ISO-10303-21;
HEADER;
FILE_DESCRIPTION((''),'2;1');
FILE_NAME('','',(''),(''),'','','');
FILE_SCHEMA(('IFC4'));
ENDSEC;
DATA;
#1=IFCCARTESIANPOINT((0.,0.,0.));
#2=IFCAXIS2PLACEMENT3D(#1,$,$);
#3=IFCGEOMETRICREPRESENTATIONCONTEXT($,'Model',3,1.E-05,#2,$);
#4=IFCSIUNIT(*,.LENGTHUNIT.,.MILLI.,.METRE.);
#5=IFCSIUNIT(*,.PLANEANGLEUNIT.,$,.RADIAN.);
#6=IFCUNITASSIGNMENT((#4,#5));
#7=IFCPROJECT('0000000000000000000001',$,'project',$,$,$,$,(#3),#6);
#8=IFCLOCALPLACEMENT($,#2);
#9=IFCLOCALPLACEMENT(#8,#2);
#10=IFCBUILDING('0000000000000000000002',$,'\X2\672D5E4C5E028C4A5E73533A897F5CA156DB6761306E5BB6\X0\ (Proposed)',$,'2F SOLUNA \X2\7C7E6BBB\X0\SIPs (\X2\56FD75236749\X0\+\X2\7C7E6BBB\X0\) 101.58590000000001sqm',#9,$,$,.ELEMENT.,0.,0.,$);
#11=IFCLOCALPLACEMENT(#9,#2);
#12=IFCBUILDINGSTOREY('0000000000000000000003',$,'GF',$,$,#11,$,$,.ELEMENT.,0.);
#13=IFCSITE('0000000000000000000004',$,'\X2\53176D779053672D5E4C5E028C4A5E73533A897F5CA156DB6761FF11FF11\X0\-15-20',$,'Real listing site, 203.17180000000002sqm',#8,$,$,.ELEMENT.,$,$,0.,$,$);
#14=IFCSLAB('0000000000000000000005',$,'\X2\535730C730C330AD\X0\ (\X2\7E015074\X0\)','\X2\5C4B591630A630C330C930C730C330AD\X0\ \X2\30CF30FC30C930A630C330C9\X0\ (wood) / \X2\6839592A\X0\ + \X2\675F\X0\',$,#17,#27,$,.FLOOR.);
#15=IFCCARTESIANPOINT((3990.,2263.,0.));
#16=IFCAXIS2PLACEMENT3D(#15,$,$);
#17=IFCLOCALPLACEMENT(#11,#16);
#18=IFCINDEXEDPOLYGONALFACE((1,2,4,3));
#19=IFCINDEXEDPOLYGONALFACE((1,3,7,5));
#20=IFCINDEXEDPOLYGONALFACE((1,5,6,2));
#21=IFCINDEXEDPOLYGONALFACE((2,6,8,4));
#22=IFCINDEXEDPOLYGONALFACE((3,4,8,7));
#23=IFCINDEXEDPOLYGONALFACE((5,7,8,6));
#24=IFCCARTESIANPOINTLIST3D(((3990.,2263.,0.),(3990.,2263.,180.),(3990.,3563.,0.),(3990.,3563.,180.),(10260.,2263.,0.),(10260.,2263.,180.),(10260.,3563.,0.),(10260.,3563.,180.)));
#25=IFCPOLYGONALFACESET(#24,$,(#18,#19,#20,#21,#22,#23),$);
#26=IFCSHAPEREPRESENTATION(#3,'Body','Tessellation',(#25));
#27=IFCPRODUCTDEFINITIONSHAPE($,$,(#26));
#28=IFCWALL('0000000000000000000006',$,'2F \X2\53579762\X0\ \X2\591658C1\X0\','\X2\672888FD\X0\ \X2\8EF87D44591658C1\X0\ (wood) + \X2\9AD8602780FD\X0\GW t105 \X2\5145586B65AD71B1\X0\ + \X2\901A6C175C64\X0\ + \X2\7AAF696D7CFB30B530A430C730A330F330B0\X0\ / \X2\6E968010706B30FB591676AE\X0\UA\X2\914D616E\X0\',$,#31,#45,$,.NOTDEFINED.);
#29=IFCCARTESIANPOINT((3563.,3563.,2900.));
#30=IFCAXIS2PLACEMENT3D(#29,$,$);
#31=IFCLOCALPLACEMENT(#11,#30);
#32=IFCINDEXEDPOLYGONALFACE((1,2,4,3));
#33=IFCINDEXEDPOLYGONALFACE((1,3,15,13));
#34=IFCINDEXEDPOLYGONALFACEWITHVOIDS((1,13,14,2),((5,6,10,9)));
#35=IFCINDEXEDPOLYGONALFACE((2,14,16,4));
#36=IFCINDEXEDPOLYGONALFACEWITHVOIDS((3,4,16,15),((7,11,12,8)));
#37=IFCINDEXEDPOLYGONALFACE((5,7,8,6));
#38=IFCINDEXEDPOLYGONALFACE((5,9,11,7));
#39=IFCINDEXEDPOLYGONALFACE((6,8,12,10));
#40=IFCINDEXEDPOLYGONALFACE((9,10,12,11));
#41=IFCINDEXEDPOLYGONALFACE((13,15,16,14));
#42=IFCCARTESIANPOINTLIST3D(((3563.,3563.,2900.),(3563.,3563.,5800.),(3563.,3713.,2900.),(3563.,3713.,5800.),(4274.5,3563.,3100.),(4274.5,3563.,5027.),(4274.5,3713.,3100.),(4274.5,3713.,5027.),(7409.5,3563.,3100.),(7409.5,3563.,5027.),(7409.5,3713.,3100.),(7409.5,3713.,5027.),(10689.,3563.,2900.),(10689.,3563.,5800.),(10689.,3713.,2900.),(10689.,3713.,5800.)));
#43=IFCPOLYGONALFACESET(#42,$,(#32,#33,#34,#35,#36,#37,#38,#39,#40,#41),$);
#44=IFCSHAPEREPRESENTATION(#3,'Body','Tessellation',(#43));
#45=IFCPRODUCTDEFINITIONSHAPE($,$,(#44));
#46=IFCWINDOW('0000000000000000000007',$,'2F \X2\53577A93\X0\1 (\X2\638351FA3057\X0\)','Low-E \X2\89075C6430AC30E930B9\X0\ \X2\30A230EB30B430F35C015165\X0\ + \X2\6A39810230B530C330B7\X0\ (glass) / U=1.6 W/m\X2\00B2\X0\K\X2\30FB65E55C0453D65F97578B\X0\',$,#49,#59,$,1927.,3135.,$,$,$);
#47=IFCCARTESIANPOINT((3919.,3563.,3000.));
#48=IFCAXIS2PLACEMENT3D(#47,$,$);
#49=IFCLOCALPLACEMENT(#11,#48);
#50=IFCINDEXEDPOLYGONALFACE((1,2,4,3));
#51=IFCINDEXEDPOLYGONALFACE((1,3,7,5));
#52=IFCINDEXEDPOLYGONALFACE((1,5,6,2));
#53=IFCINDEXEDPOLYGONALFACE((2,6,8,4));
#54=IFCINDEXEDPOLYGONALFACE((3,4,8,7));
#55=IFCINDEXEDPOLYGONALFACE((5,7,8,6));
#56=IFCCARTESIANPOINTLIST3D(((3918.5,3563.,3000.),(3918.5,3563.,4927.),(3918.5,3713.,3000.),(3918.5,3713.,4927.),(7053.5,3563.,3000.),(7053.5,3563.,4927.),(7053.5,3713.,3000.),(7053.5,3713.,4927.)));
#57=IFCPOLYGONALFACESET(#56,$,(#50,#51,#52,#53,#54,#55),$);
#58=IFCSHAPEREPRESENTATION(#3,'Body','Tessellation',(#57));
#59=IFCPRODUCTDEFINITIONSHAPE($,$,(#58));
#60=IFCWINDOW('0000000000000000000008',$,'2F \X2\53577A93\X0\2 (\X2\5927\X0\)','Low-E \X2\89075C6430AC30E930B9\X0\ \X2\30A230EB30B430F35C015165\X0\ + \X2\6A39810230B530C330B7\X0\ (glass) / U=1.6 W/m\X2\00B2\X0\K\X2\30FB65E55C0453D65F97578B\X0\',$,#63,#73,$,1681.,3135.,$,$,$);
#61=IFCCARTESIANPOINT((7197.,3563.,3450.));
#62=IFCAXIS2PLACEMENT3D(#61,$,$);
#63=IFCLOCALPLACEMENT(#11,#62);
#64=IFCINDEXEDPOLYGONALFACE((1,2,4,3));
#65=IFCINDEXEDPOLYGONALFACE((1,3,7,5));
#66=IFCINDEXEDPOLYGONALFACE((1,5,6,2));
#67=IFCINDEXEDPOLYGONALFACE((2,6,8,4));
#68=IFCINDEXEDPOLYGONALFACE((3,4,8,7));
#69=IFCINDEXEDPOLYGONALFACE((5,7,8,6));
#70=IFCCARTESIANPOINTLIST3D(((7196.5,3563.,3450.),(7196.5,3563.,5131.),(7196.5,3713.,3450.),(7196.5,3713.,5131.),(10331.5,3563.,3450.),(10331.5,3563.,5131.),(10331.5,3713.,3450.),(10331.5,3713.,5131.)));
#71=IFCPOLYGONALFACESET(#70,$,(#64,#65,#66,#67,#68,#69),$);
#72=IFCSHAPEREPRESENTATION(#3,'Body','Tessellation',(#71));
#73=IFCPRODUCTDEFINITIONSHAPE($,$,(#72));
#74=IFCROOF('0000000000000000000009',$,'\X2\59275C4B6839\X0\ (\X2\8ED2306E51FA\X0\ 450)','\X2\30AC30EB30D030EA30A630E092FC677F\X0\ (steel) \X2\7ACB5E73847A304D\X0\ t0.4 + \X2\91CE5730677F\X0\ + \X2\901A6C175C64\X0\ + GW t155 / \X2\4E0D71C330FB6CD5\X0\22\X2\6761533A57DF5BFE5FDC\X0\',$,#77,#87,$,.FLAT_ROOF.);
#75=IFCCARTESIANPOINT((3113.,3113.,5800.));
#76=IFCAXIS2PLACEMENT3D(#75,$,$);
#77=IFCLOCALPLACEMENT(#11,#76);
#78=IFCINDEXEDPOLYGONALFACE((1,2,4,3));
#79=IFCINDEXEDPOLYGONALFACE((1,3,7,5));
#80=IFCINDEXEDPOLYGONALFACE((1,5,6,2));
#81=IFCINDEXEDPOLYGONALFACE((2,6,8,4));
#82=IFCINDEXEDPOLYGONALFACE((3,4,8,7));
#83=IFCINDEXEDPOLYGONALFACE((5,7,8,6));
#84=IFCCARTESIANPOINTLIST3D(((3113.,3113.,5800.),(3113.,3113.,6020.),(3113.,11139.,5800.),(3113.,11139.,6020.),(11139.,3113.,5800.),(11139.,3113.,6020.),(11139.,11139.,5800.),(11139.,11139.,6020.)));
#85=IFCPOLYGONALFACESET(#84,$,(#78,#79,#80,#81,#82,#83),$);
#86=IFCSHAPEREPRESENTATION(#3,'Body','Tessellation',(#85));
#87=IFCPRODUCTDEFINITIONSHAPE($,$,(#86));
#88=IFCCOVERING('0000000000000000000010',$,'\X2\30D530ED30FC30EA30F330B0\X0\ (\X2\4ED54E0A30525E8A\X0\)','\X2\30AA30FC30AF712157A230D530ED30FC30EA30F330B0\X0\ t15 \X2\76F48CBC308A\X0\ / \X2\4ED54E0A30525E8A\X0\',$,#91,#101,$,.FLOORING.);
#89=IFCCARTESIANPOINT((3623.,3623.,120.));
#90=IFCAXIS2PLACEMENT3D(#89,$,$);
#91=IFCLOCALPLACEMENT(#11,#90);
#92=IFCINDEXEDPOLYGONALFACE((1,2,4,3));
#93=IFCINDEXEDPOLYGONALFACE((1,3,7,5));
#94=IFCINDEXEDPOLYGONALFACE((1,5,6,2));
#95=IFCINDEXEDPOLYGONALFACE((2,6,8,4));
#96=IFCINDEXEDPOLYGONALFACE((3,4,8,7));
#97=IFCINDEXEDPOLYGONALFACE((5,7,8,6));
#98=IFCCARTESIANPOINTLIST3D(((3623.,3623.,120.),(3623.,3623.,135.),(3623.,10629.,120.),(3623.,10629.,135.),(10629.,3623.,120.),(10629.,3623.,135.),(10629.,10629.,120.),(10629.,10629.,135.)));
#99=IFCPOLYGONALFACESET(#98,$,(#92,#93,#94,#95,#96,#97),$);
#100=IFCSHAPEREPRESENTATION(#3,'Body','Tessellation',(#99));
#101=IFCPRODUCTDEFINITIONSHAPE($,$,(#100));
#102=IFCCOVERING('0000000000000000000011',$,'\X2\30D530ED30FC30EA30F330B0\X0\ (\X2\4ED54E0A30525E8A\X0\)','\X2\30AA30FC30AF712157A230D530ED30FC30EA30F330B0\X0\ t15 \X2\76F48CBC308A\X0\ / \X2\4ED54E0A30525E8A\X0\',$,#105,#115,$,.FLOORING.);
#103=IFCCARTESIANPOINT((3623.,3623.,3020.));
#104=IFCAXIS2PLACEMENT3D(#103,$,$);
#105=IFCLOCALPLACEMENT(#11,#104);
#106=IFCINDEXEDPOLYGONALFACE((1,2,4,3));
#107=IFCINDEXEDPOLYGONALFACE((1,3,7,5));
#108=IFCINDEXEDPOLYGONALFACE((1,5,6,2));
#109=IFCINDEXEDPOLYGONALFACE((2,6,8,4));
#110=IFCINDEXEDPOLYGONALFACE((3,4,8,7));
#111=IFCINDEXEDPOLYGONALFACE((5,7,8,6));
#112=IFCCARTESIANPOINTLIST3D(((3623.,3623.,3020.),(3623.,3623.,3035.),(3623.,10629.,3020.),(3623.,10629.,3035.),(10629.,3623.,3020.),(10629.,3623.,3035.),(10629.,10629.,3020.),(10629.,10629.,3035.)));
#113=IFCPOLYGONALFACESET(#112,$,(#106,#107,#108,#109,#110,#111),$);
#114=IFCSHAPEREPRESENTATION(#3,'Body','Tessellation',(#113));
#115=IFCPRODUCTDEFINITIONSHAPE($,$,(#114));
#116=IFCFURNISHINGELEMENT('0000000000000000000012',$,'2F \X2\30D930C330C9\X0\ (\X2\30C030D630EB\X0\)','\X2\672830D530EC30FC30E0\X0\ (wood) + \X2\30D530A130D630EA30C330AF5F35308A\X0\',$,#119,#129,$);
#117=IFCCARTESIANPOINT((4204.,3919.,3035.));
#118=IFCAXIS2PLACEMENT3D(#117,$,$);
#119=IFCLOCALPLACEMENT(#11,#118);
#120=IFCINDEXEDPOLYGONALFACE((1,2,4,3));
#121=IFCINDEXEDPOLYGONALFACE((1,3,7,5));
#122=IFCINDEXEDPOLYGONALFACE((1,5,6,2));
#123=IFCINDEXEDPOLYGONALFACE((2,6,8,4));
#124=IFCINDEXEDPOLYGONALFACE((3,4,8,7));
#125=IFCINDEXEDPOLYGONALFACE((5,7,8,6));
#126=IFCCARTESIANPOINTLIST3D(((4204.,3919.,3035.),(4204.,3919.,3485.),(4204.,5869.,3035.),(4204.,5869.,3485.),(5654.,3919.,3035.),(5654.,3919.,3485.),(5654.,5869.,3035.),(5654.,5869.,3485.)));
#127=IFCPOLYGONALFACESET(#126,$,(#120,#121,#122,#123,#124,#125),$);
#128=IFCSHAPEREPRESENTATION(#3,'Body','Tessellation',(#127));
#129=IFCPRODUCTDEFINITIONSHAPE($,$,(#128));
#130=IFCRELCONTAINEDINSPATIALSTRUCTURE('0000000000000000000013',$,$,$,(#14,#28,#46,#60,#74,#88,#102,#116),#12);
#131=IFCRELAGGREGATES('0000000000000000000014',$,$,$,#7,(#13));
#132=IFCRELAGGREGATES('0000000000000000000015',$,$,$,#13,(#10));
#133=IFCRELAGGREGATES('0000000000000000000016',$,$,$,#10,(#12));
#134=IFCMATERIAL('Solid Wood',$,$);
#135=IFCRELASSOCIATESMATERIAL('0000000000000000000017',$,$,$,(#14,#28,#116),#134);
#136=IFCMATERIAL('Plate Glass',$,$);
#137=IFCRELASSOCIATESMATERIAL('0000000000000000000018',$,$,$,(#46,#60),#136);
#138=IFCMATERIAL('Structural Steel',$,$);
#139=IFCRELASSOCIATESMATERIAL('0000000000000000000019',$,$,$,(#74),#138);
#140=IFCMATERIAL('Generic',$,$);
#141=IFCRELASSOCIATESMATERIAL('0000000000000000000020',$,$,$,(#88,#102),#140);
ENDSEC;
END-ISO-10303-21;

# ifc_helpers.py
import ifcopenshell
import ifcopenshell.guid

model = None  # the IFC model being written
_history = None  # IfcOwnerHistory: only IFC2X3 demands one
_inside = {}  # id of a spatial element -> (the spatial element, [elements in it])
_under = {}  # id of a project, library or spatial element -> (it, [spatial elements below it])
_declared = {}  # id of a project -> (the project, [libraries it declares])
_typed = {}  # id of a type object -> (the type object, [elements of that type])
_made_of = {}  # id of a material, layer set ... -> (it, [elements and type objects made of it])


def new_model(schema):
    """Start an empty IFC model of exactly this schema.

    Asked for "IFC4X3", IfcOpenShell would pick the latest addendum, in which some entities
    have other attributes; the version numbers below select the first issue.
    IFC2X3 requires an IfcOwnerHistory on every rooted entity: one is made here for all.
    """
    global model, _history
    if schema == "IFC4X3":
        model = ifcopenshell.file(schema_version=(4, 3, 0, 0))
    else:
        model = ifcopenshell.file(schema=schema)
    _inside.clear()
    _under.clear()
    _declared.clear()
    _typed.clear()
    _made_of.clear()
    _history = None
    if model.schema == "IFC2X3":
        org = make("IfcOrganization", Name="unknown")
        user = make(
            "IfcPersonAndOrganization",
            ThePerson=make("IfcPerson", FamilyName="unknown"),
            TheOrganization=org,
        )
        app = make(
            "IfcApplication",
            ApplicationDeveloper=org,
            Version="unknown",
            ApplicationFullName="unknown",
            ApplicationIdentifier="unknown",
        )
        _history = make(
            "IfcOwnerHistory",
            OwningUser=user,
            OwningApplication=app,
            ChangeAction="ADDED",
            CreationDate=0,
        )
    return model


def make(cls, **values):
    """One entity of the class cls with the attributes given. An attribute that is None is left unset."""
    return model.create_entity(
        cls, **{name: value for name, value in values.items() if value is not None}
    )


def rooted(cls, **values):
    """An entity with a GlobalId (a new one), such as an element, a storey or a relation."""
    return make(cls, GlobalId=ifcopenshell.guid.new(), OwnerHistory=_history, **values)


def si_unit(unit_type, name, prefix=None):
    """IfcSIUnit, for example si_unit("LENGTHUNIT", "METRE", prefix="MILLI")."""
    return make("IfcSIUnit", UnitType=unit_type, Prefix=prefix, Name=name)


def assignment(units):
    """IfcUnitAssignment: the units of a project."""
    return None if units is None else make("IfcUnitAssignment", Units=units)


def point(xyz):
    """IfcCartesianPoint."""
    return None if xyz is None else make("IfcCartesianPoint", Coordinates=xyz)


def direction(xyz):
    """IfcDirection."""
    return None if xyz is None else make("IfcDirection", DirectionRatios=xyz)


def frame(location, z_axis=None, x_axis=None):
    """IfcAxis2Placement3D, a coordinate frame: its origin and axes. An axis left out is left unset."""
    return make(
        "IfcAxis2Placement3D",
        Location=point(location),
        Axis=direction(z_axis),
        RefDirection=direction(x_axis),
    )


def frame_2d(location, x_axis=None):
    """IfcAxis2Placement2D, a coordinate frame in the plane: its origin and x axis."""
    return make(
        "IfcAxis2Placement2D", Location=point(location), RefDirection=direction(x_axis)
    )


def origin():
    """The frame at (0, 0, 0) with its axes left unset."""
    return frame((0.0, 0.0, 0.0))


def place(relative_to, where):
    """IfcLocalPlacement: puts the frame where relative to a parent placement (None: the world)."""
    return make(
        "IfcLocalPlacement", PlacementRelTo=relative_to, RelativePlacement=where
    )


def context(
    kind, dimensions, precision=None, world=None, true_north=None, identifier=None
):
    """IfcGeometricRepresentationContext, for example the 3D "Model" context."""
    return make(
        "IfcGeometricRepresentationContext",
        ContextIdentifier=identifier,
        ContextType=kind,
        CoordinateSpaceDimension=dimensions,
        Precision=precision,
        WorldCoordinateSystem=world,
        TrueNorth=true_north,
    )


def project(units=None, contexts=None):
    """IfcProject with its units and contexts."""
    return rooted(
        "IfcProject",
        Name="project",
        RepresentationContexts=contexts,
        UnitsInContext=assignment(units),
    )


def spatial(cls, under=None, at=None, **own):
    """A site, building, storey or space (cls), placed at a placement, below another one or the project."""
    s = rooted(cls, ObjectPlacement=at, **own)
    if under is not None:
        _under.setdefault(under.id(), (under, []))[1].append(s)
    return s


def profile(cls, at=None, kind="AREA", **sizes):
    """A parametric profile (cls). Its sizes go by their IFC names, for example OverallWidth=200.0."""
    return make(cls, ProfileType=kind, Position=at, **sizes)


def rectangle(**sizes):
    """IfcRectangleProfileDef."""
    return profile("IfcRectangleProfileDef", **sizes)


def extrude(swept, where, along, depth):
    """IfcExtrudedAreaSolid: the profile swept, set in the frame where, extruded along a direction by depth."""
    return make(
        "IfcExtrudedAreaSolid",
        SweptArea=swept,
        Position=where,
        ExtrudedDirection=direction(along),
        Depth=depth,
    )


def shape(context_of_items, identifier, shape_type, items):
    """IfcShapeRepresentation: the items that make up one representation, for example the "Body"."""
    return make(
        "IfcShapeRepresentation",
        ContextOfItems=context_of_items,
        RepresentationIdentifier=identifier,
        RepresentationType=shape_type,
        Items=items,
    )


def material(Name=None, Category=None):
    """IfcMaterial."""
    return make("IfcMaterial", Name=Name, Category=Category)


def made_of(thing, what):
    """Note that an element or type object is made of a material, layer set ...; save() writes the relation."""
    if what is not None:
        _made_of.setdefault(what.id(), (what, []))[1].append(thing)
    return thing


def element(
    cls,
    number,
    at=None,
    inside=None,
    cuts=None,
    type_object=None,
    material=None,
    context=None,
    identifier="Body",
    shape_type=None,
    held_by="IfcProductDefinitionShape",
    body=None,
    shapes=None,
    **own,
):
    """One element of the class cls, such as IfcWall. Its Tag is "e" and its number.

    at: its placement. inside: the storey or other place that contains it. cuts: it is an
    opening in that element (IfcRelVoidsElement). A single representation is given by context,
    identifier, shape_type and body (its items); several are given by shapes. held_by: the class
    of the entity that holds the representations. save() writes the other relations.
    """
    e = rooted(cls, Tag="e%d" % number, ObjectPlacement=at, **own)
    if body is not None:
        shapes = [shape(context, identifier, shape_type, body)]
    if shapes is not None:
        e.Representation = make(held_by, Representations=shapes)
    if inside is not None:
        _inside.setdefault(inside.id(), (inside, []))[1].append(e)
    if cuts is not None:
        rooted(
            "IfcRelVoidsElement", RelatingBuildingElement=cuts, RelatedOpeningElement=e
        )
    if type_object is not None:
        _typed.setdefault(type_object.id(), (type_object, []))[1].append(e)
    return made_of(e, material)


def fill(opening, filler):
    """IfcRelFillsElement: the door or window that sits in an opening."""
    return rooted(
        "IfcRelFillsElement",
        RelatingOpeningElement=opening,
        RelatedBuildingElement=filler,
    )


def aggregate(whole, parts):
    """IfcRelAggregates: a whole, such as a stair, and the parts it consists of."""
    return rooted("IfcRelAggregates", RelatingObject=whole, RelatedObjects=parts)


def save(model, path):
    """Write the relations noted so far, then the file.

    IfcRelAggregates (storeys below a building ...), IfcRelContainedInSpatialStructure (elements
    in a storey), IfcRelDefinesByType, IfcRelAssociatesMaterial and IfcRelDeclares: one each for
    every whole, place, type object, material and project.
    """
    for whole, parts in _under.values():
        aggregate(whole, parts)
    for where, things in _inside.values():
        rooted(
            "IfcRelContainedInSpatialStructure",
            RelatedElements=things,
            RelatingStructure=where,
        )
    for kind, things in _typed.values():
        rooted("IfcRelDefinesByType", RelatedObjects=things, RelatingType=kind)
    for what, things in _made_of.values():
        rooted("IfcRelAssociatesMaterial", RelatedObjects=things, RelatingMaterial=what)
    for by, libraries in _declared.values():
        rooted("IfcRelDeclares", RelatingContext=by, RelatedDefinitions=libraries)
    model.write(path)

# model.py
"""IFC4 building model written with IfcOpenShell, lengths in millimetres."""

from ifc_helpers import new_model, si_unit, frame, frame_2d, origin, place, context, project, spatial, rectangle, extrude, material, element, fill, save


model = new_model("IFC4")

# Units and contexts
model_context = context("Model", 3, precision=1e-05, world=origin())
ifc_project = project(units=[si_unit("LENGTHUNIT", "METRE", prefix="MILLI"), si_unit("PLANEANGLEUNIT", "RADIAN")], contexts=[model_context])

# Site, building, storey
site_placement = place(None, origin())
site = spatial("IfcSite", under=ifc_project, at=site_placement, Name="北海道札幌市豊平区西岡四条１１-15-20", ObjectType="Real listing site, 203.17180000000002sqm", CompositionType="ELEMENT", RefElevation=0.0)
building_placement = place(site_placement, origin())
building = spatial("IfcBuilding", under=site, at=building_placement, Name="札幌市豊平区西岡四条の家 (Proposed)", ObjectType="2F SOLUNA 籾殻SIPs (国産杉+籾殻) 101.58590000000001sqm", CompositionType="ELEMENT", ElevationOfRefHeight=0.0, ElevationOfTerrain=0.0)
storey_placement = place(building_placement, origin())
storey = spatial("IfcBuildingStorey", under=building, at=storey_placement, Name="GF", CompositionType="ELEMENT", Elevation=0.0)

# Slab
ifc_material_1 = material(Name="Solid Wood")
slab_1_placement = place(storey_placement, frame((3990.0, 2263.0, 0.0)))
element("IfcSlab", 1, at=slab_1_placement, inside=storey, material=ifc_material_1, Name="南デッキ (縁側)", Description="屋外ウッドデッキ ハードウッド (wood) / 根太 + 束", PredefinedType="FLOOR", context=model_context, shape_type="SweptSolid", body=[
    extrude(rectangle(XDim=6270.0, YDim=1300.0, at=frame_2d((3135.0, 650.0))), frame((3990.0, 2263.0, 0.0)), (0.0, 0.0, 1.0), 180.0),
])

# Shared definitions
ifc_material_2 = material(Name="Plate Glass")

# Wall, openings, windows
wall_1_placement = place(storey_placement, frame((3563.0, 3563.0, 2900.0)))
wall_1 = element("IfcWall", 2, at=wall_1_placement, inside=storey, material=ifc_material_1, Name="2F 南面 外壁", Description="木製 軸組外壁 (wood) + 高性能GW t105 充填断熱 + 通気層 + 窯業系サイディング / 準耐火・外皮UA配慮", PredefinedType="NOTDEFINED", context=model_context, shape_type="SweptSolid", body=[
    extrude(rectangle(XDim=7126.0, YDim=150.0, at=frame_2d((3563.0, 75.0))), frame((3563.0, 3563.0, 2900.0)), (0.0, 0.0, 1.0), 2900.0),
])
opening_1_placement = place(storey_placement, frame((3919.0, 3563.0, 3000.0)))
opening_1 = element("IfcOpeningElement", 3, at=opening_1_placement, cuts=wall_1, PredefinedType="NOTDEFINED", context=model_context, shape_type="SweptSolid", body=[
    extrude(rectangle(XDim=3135.0, YDim=150.0, at=frame_2d((1567.0, 75.0))), frame((3919.0, 3563.0, 3000.0)), (0.0, 0.0, 1.0), 1927.0),
])
opening_2_placement = place(storey_placement, frame((7197.0, 3563.0, 3450.0)))
opening_2 = element("IfcOpeningElement", 4, at=opening_2_placement, cuts=wall_1, PredefinedType="NOTDEFINED", context=model_context, shape_type="SweptSolid", body=[
    extrude(rectangle(XDim=3135.0, YDim=150.0, at=frame_2d((1567.0, 75.0))), frame((7197.0, 3563.0, 3450.0)), (0.0, 0.0, 1.0), 1681.0),
])
window_1_placement = place(storey_placement, frame((3919.0, 3563.0, 3000.0)))
window_1 = element("IfcWindow", 5, at=window_1_placement, inside=storey, material=ifc_material_2, Name="2F 南窓1 (掃出し)", Description="Low-E 複層ガラス アルゴン封入 + 樹脂サッシ (glass) / U=1.6 W/m²K・日射取得型", OverallHeight=1927.0, OverallWidth=3135.0, context=model_context, shape_type="SweptSolid", body=[
    extrude(rectangle(XDim=3135.0, YDim=150.0, at=frame_2d((1567.0, 75.0))), frame((3919.0, 3563.0, 3000.0)), (0.0, 0.0, 1.0), 1927.0),
])
fill(opening_1, window_1)
window_2_placement = place(storey_placement, frame((7197.0, 3563.0, 3450.0)))
window_2 = element("IfcWindow", 6, at=window_2_placement, inside=storey, material=ifc_material_2, Name="2F 南窓2 (大)", Description="Low-E 複層ガラス アルゴン封入 + 樹脂サッシ (glass) / U=1.6 W/m²K・日射取得型", OverallHeight=1681.0, OverallWidth=3135.0, context=model_context, shape_type="SweptSolid", body=[
    extrude(rectangle(XDim=3135.0, YDim=150.0, at=frame_2d((1567.0, 75.0))), frame((7197.0, 3563.0, 3450.0)), (0.0, 0.0, 1.0), 1681.0),
])
fill(opening_2, window_2)

# Roof
ifc_material_3 = material(Name="Structural Steel")
roof_placement = place(storey_placement, frame((3113.0, 3113.0, 5800.0)))
element("IfcRoof", 7, at=roof_placement, inside=storey, material=ifc_material_3, Name="大屋根 (軒の出 450)", Description="ガルバリウム鋼板 (steel) 立平葺き t0.4 + 野地板 + 通気層 + GW t155 / 不燃・法22条区域対応", PredefinedType="FLAT_ROOF", context=model_context, shape_type="SweptSolid", body=[
    extrude(rectangle(XDim=8026.0, YDim=8026.0, at=frame_2d((4013.0, 4013.0))), frame((3113.0, 3113.0, 5800.0)), (0.0, 0.0, 1.0), 220.0),
])

# Coverings
ifc_material_4 = material(Name="Generic")
covering_1_placement = place(storey_placement, frame((3623.0, 3623.0, 120.0)))
element("IfcCovering", 8, at=covering_1_placement, inside=storey, material=ifc_material_4, Name="フローリング (仕上げ床)", Description="オーク無垢フローリング t15 直貼り / 仕上げ床", PredefinedType="FLOORING", context=model_context, shape_type="SweptSolid", body=[
    extrude(rectangle(XDim=7006.0, YDim=7006.0, at=frame_2d((3503.0, 3503.0))), frame((3623.0, 3623.0, 120.0)), (0.0, 0.0, 1.0), 15.0),
])
covering_2_placement = place(storey_placement, frame((3623.0, 3623.0, 3020.0)))
element("IfcCovering", 9, at=covering_2_placement, inside=storey, material=ifc_material_4, Name="フローリング (仕上げ床)", Description="オーク無垢フローリング t15 直貼り / 仕上げ床", PredefinedType="FLOORING", context=model_context, shape_type="SweptSolid", body=[
    extrude(rectangle(XDim=7006.0, YDim=7006.0, at=frame_2d((3503.0, 3503.0))), frame((3623.0, 3623.0, 3020.0)), (0.0, 0.0, 1.0), 15.0),
])

# Furnishing element
furnishing_placement = place(storey_placement, frame((4204.0, 3919.0, 3035.0)))
element("IfcFurnishingElement", 10, at=furnishing_placement, inside=storey, material=ifc_material_1, Name="2F ベッド (ダブル)", Description="木フレーム (wood) + ファブリック張り", context=model_context, shape_type="SweptSolid", body=[
    extrude(rectangle(XDim=1450.0, YDim=1950.0, at=frame_2d((725.0, 975.0))), frame((4204.0, 3919.0, 3035.0)), (0.0, 0.0, 1.0), 450.0),
])

save(model, "model.ifc")
